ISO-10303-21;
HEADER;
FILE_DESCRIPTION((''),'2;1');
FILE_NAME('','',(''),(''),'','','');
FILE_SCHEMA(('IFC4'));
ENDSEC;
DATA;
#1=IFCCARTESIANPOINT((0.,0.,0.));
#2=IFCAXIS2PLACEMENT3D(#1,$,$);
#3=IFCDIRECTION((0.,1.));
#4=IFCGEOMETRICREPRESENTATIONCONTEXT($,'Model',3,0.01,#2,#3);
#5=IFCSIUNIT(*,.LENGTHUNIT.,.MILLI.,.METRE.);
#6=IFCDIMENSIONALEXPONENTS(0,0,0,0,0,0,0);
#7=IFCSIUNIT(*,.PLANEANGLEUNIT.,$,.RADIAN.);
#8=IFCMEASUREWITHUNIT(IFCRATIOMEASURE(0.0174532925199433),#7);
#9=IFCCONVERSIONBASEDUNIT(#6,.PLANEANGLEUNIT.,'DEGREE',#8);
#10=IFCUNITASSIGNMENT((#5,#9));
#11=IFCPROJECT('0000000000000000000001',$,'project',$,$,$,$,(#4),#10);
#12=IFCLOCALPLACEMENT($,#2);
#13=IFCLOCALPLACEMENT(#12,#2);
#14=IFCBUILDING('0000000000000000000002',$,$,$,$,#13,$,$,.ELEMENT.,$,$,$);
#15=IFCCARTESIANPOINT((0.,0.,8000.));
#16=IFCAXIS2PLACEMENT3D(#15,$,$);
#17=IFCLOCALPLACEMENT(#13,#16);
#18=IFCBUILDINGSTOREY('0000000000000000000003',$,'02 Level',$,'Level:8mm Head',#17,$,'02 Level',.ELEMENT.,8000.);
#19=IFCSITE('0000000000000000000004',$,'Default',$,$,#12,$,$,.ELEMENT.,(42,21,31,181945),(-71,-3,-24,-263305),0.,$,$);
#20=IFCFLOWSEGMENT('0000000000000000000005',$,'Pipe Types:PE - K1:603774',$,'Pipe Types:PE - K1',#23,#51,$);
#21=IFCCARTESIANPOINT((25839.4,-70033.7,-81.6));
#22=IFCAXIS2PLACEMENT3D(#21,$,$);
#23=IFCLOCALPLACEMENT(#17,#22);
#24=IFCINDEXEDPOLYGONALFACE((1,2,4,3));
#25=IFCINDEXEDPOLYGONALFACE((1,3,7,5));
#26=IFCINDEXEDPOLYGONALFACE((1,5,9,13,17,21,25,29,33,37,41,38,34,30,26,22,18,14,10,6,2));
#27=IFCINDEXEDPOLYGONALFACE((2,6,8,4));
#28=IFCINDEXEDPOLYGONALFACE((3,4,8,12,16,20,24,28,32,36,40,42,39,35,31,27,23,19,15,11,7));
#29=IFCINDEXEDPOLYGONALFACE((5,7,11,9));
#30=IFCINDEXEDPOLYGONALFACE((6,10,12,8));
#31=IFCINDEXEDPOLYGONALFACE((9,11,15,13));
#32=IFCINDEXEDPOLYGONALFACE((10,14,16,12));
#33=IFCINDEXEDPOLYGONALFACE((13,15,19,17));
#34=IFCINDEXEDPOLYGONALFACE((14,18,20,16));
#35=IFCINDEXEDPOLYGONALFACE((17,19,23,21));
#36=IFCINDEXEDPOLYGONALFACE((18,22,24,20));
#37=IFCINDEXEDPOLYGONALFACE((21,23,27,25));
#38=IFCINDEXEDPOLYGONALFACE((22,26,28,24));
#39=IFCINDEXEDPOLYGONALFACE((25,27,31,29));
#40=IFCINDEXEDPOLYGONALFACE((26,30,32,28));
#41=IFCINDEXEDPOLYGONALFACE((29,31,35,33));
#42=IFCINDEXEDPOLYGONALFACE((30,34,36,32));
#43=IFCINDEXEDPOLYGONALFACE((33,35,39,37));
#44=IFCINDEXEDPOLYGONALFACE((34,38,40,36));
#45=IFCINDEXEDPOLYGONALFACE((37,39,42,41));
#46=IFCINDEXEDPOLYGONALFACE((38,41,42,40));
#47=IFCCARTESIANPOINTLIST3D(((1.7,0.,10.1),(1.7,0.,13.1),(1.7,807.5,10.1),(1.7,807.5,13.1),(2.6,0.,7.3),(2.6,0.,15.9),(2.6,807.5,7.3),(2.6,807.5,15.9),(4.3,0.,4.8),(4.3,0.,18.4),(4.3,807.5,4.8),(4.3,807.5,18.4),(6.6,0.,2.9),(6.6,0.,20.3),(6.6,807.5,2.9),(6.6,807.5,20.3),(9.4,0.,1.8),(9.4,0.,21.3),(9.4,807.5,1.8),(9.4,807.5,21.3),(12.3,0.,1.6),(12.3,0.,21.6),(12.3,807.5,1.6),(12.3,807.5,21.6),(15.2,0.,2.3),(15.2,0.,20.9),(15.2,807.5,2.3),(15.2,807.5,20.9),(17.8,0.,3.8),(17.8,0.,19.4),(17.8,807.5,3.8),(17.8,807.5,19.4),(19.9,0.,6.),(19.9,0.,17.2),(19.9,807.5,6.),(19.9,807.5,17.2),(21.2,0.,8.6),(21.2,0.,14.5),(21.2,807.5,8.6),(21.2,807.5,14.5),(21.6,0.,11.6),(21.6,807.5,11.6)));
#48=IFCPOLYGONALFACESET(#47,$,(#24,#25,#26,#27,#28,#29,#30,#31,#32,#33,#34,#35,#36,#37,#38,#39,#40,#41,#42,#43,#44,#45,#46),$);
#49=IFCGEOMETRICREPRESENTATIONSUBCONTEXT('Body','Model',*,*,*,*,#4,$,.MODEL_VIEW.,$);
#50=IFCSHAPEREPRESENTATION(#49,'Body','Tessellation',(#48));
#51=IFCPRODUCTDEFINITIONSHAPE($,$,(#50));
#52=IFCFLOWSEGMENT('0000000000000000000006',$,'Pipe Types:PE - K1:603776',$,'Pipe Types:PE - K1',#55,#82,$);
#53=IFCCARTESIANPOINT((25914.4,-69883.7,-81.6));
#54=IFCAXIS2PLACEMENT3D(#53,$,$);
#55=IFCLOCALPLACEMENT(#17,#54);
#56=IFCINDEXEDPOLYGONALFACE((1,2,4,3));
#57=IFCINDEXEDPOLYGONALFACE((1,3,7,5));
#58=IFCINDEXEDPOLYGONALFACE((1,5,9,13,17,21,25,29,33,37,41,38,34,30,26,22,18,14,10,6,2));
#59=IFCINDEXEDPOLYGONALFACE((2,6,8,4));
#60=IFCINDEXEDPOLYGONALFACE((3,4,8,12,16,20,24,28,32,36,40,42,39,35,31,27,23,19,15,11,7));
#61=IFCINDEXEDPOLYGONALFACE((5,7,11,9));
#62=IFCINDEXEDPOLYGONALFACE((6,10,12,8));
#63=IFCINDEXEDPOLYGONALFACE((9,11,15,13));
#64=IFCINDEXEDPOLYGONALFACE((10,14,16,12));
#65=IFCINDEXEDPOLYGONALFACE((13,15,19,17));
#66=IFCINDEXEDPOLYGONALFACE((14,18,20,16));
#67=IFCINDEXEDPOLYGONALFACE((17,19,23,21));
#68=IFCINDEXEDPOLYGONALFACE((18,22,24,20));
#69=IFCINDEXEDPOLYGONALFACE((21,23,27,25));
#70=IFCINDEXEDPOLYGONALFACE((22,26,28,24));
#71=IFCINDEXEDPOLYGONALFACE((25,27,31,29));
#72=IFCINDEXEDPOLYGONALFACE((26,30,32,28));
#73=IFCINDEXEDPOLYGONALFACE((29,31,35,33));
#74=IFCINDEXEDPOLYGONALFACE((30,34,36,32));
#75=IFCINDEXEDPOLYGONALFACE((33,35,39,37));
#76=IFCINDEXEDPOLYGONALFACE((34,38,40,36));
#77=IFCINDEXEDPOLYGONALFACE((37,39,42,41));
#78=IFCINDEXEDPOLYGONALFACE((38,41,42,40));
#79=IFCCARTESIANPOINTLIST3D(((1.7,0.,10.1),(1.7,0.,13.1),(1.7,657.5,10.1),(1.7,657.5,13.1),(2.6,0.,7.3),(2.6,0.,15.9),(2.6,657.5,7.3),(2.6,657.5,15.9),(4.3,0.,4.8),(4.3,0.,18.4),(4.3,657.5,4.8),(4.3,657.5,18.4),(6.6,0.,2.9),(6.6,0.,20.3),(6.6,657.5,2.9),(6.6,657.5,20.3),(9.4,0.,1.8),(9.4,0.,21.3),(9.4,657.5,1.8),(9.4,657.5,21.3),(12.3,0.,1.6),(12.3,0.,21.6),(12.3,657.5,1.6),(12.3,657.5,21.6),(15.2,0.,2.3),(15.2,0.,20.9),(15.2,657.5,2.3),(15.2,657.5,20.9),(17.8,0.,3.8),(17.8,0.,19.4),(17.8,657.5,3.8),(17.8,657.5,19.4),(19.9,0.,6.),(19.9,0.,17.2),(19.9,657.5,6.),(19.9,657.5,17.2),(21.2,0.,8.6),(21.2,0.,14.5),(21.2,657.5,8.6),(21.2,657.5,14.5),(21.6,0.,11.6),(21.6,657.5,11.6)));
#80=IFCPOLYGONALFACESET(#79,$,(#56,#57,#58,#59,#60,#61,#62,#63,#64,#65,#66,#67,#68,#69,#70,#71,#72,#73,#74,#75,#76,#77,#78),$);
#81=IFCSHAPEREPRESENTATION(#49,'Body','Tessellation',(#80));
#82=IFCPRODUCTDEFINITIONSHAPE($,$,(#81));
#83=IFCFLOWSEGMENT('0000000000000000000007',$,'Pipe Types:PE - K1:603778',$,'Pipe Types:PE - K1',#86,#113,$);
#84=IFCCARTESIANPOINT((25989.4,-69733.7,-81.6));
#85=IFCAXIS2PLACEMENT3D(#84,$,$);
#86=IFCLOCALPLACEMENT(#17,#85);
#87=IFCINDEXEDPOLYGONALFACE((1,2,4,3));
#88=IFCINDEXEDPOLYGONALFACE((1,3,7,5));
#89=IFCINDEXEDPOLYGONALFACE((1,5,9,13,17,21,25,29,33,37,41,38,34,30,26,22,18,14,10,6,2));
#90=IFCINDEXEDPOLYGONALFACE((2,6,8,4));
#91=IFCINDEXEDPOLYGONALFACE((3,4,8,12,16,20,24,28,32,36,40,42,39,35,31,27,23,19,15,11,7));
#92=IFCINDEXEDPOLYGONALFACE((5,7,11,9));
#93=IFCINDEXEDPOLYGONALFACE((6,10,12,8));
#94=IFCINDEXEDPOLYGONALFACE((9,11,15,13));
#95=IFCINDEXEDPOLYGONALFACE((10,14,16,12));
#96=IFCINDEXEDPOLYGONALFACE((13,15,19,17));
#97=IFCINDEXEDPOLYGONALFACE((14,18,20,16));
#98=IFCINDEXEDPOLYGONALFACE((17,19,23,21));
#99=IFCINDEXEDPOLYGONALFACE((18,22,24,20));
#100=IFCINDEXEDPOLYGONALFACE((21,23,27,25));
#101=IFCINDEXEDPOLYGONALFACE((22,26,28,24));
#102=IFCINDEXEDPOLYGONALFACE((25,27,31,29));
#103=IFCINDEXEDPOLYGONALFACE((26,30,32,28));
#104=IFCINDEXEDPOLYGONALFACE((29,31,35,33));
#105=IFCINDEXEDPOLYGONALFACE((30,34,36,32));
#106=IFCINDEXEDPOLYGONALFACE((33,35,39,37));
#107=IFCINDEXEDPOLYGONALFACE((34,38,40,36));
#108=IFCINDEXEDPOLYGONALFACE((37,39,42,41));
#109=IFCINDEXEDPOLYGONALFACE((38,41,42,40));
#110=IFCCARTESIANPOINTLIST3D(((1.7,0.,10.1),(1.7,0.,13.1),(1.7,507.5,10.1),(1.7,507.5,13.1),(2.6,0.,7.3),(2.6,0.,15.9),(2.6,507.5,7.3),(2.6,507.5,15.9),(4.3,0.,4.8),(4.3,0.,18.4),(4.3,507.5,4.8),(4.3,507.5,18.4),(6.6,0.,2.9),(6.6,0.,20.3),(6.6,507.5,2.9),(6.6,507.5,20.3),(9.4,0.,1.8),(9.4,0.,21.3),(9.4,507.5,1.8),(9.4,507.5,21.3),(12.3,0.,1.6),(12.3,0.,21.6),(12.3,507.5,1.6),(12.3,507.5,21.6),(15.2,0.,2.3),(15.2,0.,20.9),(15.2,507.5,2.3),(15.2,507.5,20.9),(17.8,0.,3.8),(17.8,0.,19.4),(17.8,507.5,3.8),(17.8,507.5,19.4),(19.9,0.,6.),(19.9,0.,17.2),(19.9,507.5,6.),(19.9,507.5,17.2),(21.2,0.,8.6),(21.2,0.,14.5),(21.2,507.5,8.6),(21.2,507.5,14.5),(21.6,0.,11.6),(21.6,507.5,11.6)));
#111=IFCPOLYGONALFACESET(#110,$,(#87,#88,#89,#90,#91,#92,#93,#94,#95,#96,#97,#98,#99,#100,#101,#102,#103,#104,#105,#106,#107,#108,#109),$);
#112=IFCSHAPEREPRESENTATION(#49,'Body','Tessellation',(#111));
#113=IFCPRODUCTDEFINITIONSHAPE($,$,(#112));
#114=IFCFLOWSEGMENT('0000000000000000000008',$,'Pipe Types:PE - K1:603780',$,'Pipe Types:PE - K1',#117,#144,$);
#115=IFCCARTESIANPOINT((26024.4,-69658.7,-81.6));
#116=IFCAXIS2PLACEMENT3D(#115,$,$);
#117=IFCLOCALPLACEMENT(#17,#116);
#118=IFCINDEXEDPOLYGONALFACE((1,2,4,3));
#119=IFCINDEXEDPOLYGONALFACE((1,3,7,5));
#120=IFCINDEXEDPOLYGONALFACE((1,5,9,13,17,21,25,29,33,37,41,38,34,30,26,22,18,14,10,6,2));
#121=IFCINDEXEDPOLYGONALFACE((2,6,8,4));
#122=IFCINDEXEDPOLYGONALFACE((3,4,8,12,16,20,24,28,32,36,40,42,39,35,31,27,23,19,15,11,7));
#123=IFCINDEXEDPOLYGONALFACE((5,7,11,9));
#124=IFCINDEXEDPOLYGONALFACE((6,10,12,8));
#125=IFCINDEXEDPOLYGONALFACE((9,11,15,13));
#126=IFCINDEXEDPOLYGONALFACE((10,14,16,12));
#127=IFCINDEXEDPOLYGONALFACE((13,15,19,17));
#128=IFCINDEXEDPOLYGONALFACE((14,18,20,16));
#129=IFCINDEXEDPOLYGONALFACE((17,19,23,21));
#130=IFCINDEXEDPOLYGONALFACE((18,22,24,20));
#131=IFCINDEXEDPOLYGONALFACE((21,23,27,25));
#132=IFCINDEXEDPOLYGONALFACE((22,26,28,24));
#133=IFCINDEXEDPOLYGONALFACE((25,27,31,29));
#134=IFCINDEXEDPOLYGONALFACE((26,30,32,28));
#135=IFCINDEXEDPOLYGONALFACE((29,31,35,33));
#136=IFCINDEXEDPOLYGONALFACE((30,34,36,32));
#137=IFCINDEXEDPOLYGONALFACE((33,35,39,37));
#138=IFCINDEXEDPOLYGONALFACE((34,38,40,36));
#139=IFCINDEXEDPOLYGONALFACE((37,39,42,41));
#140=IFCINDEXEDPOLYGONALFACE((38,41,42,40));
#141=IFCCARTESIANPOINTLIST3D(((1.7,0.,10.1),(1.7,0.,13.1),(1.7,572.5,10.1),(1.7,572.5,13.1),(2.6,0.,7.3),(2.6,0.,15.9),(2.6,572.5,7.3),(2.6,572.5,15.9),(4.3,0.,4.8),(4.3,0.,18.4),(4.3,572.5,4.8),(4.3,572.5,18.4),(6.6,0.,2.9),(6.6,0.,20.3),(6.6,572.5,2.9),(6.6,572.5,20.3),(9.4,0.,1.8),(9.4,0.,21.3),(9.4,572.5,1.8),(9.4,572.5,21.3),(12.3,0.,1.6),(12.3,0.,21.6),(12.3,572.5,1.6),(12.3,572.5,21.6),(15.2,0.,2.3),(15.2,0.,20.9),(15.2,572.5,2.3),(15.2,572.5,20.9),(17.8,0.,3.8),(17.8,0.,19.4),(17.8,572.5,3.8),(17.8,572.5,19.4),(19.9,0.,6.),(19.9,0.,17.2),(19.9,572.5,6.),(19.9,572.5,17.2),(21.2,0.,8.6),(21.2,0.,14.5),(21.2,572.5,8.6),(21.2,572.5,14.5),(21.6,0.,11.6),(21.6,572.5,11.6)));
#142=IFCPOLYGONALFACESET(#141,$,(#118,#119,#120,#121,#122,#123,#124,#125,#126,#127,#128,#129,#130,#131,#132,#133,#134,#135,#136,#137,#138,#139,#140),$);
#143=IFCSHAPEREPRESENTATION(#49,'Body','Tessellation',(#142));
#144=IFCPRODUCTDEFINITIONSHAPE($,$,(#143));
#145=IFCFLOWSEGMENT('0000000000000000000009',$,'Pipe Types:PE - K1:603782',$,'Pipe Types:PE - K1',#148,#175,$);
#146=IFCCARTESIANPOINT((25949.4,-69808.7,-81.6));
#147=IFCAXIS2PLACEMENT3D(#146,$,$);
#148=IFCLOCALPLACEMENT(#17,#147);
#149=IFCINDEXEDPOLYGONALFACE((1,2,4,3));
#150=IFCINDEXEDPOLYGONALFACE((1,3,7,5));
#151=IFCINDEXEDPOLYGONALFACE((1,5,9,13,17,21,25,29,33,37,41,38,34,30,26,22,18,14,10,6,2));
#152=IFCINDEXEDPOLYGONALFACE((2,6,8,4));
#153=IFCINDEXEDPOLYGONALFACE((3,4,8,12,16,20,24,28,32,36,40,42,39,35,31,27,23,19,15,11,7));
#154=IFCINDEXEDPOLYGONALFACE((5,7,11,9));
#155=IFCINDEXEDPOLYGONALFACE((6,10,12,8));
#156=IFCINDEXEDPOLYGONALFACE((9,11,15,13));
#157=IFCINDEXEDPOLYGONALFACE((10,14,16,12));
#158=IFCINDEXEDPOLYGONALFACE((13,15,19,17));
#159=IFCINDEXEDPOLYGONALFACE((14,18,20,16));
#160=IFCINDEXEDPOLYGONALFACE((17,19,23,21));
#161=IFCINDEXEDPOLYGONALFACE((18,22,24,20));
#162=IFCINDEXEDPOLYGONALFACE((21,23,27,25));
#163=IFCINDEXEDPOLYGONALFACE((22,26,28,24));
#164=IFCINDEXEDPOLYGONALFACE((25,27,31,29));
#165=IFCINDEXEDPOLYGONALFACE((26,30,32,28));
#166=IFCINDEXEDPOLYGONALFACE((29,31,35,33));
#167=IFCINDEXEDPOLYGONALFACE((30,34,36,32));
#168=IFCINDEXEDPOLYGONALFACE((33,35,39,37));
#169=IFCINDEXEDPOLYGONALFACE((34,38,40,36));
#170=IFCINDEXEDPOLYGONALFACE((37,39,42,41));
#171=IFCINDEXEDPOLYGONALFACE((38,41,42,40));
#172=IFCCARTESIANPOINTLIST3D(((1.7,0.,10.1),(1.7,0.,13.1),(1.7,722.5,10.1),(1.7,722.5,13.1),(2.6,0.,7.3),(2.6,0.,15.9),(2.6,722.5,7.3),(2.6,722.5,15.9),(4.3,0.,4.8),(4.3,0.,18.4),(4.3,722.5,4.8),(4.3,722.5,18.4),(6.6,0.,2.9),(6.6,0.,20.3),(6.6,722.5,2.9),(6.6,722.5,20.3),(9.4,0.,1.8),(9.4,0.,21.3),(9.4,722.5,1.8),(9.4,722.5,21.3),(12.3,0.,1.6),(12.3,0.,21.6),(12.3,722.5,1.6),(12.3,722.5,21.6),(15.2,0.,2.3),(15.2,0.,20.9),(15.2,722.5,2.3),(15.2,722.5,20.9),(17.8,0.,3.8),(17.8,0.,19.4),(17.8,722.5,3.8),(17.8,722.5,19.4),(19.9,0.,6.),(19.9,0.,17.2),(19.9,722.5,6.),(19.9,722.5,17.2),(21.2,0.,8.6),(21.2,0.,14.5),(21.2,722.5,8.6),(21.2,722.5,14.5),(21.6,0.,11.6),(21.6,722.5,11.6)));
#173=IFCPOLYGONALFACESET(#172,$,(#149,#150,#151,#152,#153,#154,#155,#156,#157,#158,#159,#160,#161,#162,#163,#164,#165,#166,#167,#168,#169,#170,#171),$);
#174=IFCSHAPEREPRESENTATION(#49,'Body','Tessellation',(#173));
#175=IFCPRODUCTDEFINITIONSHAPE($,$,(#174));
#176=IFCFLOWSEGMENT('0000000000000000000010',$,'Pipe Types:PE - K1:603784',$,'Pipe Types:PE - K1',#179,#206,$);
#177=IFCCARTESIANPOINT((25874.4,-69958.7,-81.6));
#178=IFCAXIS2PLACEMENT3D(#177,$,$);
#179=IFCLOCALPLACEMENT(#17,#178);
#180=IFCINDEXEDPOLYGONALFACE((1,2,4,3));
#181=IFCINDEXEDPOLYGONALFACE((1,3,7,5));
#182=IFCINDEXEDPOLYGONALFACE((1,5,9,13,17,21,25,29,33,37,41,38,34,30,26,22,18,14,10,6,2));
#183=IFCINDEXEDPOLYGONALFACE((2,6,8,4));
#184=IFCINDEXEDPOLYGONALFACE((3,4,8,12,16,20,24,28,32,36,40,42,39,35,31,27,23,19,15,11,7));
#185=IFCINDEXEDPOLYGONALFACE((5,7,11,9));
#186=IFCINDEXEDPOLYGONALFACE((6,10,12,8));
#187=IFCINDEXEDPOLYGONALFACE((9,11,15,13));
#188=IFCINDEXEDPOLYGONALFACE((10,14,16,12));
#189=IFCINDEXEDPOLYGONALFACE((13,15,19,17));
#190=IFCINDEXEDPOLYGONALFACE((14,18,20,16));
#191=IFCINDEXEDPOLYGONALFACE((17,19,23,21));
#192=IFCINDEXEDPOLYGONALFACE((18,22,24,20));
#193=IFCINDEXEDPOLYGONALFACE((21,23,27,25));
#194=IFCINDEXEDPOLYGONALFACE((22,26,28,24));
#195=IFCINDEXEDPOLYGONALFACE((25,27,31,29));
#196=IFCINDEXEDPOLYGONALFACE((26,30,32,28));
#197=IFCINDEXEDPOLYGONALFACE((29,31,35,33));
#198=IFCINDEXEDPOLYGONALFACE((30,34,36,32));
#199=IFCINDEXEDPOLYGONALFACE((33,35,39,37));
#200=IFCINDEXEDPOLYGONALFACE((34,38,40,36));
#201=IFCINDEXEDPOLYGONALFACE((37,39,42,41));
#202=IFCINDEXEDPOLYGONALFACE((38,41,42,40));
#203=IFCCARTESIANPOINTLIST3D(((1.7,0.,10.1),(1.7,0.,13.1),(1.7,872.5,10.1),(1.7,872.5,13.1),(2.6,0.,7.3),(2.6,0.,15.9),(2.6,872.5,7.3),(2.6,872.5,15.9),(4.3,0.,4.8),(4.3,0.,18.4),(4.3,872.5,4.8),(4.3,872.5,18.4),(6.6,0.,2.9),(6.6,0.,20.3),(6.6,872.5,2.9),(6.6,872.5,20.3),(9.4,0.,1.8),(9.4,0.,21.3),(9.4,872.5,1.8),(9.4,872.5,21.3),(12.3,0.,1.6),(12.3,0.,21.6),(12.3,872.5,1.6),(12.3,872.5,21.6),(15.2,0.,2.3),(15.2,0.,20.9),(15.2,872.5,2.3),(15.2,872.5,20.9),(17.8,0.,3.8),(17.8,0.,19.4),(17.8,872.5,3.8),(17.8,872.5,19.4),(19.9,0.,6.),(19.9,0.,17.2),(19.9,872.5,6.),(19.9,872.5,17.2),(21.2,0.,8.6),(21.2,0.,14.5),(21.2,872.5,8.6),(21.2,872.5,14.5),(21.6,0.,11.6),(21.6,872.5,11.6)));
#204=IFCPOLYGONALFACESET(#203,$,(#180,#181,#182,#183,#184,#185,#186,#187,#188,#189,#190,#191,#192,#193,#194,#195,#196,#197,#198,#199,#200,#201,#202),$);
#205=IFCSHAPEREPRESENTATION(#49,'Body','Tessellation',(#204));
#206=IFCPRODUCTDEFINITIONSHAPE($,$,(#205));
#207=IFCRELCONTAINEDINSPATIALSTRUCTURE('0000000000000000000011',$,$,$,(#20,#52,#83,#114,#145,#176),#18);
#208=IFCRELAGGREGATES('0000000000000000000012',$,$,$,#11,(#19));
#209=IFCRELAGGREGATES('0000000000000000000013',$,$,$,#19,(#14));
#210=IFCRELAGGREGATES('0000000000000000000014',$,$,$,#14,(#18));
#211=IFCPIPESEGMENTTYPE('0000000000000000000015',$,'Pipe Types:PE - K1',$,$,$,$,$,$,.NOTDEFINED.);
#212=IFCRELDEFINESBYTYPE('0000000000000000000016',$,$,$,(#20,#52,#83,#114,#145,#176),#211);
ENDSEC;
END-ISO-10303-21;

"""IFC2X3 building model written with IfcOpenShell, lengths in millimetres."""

from ifc_helpers import new_model, entity, si_unit, converted_unit, direction, frame, origin, origin_2d_with_axis, place, context, subcontext, project, spatial, circle, extrude, type_object, element, save


model = new_model("IFC2X3")

# Units and contexts
model_context = context("Model", 3, precision=0.01, world=origin(), true_north=direction((0.0, 1.0)))
body_context = subcontext(model_context, "Body", "Model", "MODEL_VIEW")
ifc_project = project(units=[si_unit("LENGTHUNIT", "METRE", prefix="MILLI"), converted_unit("PLANEANGLEUNIT", "DEGREE", entity("IfcRatioMeasure", 0.0174532925199433), si_unit("PLANEANGLEUNIT", "RADIAN"), dimensions=[0, 0, 0, 0, 0, 0, 0])], contexts=[model_context])

# Site, building, storey
site_placement = place(None, origin())
site = spatial("IfcSite", under=ifc_project, at=site_placement, Name="Default", CompositionType="ELEMENT", RefLatitude=(42, 21, 31, 181945), RefLongitude=(-71, -3, -24, -263305), RefElevation=0.0)
building_placement = place(site_placement, origin())
building = spatial("IfcBuilding", under=site, at=building_placement, CompositionType="ELEMENT")
storey_placement = place(building_placement, frame((0.0, 0.0, 8000.0)))
storey = spatial("IfcBuildingStorey", under=building, at=storey_placement, Name="02 Level", ObjectType="Level:8mm Head", LongName="02 Level", CompositionType="ELEMENT", Elevation=8000.0)

# Flow segments
pipe_segment_type = type_object("IfcPipeSegmentType", Name="Pipe Types:PE - K1", PredefinedType="NOTDEFINED")
flow_segment_1_placement = place(storey_placement, frame((25839.4, -70033.7, -81.6)))
element("IfcFlowSegment", 1, at=flow_segment_1_placement, inside=storey, type_object=pipe_segment_type, Name="Pipe Types:PE - K1:603774", ObjectType="Pipe Types:PE - K1", context=body_context, shape_type="SweptSolid", body=[
    extrude(circle(Radius=10.0, at=origin_2d_with_axis()), frame((11.6, 0.0, 11.6), z_axis=(0.0, 1.0, 0.0), x_axis=(1.0, 0.0, 0.0)), (0.0, 0.0, 1.0), 807.5),
])
flow_segment_2_placement = place(storey_placement, frame((25914.4, -69883.7, -81.6)))
element("IfcFlowSegment", 2, at=flow_segment_2_placement, inside=storey, type_object=pipe_segment_type, Name="Pipe Types:PE - K1:603776", ObjectType="Pipe Types:PE - K1", context=body_context, shape_type="SweptSolid", body=[
    extrude(circle(Radius=10.0, at=origin_2d_with_axis()), frame((11.6, 0.0, 11.6), z_axis=(0.0, 1.0, 0.0), x_axis=(1.0, 0.0, 0.0)), (0.0, 0.0, 1.0), 657.5),
])
flow_segment_3_placement = place(storey_placement, frame((25989.4, -69733.7, -81.6)))
element("IfcFlowSegment", 3, at=flow_segment_3_placement, inside=storey, type_object=pipe_segment_type, Name="Pipe Types:PE - K1:603778", ObjectType="Pipe Types:PE - K1", context=body_context, shape_type="SweptSolid", body=[
    extrude(circle(Radius=10.0, at=origin_2d_with_axis()), frame((11.6, 0.0, 11.6), z_axis=(0.0, 1.0, 0.0), x_axis=(1.0, 0.0, 0.0)), (0.0, 0.0, 1.0), 507.5),
])
flow_segment_4_placement = place(storey_placement, frame((26024.4, -69658.7, -81.6)))
element("IfcFlowSegment", 4, at=flow_segment_4_placement, inside=storey, type_object=pipe_segment_type, Name="Pipe Types:PE - K1:603780", ObjectType="Pipe Types:PE - K1", context=body_context, shape_type="SweptSolid", body=[
    extrude(circle(Radius=10.0, at=origin_2d_with_axis()), frame((11.6, 0.0, 11.6), z_axis=(0.0, 1.0, 0.0), x_axis=(1.0, 0.0, 0.0)), (0.0, 0.0, 1.0), 572.5),
])
flow_segment_5_placement = place(storey_placement, frame((25949.4, -69808.7, -81.6)))
element("IfcFlowSegment", 5, at=flow_segment_5_placement, inside=storey, type_object=pipe_segment_type, Name="Pipe Types:PE - K1:603782", ObjectType="Pipe Types:PE - K1", context=body_context, shape_type="SweptSolid", body=[
    extrude(circle(Radius=10.0, at=origin_2d_with_axis()), frame((11.6, 0.0, 11.6), z_axis=(0.0, 1.0, 0.0), x_axis=(1.0, 0.0, 0.0)), (0.0, 0.0, 1.0), 722.5),
])
flow_segment_6_placement = place(storey_placement, frame((25874.4, -69958.7, -81.6)))
element("IfcFlowSegment", 6, at=flow_segment_6_placement, inside=storey, type_object=pipe_segment_type, Name="Pipe Types:PE - K1:603784", ObjectType="Pipe Types:PE - K1", context=body_context, shape_type="SweptSolid", body=[
    extrude(circle(Radius=10.0, at=origin_2d_with_axis()), frame((11.6, 0.0, 11.6), z_axis=(0.0, 1.0, 0.0), x_axis=(1.0, 0.0, 0.0)), (0.0, 0.0, 1.0), 872.5),
])

save(model, "model.ifc")
